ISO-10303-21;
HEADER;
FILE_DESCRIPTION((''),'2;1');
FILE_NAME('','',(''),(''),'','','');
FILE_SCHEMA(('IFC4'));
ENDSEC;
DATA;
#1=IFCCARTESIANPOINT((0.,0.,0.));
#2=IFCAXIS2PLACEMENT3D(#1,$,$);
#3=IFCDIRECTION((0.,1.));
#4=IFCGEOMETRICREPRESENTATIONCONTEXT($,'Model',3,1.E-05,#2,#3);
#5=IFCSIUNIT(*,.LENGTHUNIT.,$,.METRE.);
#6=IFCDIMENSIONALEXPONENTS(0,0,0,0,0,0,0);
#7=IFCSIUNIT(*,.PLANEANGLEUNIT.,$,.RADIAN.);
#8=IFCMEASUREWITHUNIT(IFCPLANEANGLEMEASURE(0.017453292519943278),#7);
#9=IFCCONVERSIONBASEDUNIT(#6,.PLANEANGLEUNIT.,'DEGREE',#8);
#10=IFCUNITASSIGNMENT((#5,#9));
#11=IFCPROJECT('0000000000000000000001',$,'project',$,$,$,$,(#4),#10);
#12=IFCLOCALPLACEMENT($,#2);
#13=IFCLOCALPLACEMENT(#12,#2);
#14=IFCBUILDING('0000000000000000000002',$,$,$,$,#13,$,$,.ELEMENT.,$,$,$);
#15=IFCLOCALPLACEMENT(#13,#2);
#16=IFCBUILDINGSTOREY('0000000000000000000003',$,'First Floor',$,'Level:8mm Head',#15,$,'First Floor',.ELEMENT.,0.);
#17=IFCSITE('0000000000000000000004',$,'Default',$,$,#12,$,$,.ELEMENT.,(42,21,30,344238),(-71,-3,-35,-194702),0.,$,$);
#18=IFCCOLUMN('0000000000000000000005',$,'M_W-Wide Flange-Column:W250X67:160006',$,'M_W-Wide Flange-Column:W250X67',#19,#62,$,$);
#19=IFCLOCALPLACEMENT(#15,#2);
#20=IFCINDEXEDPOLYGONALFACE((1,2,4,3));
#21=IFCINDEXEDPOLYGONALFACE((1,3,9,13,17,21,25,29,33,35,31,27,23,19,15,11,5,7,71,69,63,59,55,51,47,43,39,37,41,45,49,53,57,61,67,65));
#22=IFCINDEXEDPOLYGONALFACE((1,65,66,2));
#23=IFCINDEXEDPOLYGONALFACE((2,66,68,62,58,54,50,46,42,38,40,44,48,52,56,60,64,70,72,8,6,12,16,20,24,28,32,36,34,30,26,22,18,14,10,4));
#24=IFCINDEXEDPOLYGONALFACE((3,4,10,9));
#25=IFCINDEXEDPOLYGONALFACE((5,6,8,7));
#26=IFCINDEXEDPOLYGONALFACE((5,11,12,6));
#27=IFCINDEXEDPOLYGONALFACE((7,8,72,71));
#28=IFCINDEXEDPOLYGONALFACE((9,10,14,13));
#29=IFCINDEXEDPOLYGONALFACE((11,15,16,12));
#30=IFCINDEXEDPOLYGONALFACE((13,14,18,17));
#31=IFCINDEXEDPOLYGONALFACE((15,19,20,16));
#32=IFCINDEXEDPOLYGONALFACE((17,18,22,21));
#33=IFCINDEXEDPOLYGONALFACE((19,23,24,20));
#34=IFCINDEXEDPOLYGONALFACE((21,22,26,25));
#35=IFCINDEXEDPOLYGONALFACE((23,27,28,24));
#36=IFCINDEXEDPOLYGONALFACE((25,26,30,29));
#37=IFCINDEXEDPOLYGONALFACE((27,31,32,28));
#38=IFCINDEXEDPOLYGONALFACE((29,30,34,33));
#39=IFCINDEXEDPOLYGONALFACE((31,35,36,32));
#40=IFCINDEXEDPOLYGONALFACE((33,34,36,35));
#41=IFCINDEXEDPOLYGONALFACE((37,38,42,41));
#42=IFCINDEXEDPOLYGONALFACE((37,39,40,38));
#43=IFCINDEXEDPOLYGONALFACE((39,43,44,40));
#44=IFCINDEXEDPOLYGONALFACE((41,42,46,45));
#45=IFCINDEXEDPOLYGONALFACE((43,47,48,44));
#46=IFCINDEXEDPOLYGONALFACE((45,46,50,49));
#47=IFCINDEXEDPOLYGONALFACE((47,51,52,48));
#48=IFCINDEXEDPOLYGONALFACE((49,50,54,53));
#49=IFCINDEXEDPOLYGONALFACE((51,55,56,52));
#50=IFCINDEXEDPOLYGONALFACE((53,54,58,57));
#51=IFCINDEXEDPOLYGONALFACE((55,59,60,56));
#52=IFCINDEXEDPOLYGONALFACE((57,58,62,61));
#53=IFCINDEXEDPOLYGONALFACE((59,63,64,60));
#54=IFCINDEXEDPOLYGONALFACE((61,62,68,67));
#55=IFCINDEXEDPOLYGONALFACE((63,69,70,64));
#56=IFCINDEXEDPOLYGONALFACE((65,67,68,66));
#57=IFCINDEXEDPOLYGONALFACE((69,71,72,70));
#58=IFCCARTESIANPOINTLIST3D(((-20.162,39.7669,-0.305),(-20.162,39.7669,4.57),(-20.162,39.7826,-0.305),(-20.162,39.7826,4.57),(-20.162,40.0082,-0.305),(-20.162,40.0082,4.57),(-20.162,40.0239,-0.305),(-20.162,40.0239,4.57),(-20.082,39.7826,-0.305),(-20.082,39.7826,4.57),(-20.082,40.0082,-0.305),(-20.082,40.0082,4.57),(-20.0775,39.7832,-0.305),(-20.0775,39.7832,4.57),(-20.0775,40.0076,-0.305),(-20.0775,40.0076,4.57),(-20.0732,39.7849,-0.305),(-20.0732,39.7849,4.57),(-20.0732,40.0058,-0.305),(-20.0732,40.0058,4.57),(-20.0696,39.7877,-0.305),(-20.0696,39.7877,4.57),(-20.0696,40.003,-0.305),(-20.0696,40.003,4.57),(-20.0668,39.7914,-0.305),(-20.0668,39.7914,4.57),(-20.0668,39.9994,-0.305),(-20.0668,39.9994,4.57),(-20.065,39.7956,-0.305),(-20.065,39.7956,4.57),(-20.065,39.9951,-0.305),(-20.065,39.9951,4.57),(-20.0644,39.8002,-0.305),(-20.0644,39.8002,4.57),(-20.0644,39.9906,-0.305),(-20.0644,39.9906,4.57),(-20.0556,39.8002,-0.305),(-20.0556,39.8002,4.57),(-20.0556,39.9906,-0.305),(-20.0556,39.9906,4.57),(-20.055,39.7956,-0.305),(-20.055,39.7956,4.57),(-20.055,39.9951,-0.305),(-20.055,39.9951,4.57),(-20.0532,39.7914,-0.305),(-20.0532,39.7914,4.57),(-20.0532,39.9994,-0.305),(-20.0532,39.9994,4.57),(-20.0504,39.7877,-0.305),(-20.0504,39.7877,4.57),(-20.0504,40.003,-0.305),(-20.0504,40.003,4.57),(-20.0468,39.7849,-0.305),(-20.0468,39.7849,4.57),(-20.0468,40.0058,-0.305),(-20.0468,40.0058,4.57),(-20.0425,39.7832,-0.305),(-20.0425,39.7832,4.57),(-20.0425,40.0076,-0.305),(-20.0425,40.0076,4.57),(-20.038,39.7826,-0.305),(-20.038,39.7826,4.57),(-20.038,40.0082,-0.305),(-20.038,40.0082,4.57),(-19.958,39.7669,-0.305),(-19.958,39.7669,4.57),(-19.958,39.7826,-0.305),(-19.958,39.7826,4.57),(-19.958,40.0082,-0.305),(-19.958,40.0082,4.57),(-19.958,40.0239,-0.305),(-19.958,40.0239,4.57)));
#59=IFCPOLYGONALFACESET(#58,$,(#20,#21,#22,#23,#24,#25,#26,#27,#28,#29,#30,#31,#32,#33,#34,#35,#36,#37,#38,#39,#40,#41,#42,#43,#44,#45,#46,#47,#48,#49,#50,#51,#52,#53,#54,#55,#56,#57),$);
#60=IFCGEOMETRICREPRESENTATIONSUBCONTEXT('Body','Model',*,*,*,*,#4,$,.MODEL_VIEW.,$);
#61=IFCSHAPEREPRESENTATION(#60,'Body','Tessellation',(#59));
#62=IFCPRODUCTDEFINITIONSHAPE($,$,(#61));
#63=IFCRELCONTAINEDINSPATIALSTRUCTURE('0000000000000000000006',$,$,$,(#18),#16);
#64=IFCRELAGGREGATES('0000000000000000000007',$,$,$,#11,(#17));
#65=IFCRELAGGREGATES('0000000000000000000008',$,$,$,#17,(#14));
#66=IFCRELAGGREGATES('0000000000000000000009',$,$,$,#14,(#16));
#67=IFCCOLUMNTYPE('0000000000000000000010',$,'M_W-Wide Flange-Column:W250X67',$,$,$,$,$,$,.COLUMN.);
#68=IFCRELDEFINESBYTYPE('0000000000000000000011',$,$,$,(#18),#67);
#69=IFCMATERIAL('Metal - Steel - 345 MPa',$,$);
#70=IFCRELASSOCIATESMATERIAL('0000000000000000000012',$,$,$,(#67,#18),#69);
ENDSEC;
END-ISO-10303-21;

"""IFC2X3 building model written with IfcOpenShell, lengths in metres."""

from ifc_helpers import new_model, entity, si_unit, converted_unit, direction, frame, frame_2d, origin, place, context, subcontext, project, spatial, i_section, extrude, source, transform, mapped, material, type_object, type_shapes, element, save


model = new_model("IFC2X3")

# Units and contexts
model_context = context("Model", 3, precision=1e-05, world=origin(), true_north=direction((0.0, 1.0)))
body_context = subcontext(model_context, "Body", "Model", "MODEL_VIEW")
ifc_project = project(units=[si_unit("LENGTHUNIT", "METRE"), converted_unit("PLANEANGLEUNIT", "DEGREE", entity("IfcPlaneAngleMeasure", 0.017453292519943278), si_unit("PLANEANGLEUNIT", "RADIAN"), dimensions=[0, 0, 0, 0, 0, 0, 0])], contexts=[model_context])

# Site, building, storey
site_placement = place(None, origin())
site = spatial("IfcSite", under=ifc_project, at=site_placement, Name="Default", CompositionType="ELEMENT", RefLatitude=(42, 21, 30, 344238), RefLongitude=(-71, -3, -35, -194702), RefElevation=0.0)
building_placement = place(site_placement, origin())
building = spatial("IfcBuilding", under=site, at=building_placement, CompositionType="ELEMENT")
storey_placement = place(building_placement, origin())
storey = spatial("IfcBuildingStorey", under=building, at=storey_placement, Name="First Floor", ObjectType="Level:8mm Head", LongName="First Floor", CompositionType="ELEMENT", Elevation=0.0)

# Column
ifc_material_1 = material(Name="Metal - Steel - 345 MPa")
column_type = type_object("IfcColumnType", Name="M_W-Wide Flange-Column:W250X67", PredefinedType="COLUMN", material=ifc_material_1)
shared_shape_1 = source(origin(), body_context, "Body", "SweptSolid", [
    extrude(i_section(OverallWidth=0.204, OverallDepth=0.257, WebThickness=0.0089, FlangeThickness=0.0157, FilletRadius=0.0176, at=frame_2d((0.0, 0.0), x_axis=(1.0, 0.0))), frame((0.0, 0.0, -0.305), z_axis=(0.0, 0.0, 1.0), x_axis=(-1.0, 0.0, 0.0)), (0.0, 0.0, 1.0), 4.875),
])
type_shapes(column_type, [shared_shape_1])
for number, where, z_axis, x_axis, name in (
    (1, (-20.06, 39.8954, 0.0), (0.0, 0.0, 1.0), (-1.0, 0.0, 0.0), "M_W-Wide Flange-Column:W250X67:160006"),
):
    element("IfcColumn", number, at=place(storey_placement, frame(where, z_axis=z_axis, x_axis=x_axis)), inside=storey, type_object=column_type, material=ifc_material_1, Name=name, ObjectType="M_W-Wide Flange-Column:W250X67", context=body_context, shape_type="MappedRepresentation", body=[
        mapped(shared_shape_1, transform((0.0, 0.0, 0.0), scale=1.0)),
    ])

save(model, "model.ifc")
